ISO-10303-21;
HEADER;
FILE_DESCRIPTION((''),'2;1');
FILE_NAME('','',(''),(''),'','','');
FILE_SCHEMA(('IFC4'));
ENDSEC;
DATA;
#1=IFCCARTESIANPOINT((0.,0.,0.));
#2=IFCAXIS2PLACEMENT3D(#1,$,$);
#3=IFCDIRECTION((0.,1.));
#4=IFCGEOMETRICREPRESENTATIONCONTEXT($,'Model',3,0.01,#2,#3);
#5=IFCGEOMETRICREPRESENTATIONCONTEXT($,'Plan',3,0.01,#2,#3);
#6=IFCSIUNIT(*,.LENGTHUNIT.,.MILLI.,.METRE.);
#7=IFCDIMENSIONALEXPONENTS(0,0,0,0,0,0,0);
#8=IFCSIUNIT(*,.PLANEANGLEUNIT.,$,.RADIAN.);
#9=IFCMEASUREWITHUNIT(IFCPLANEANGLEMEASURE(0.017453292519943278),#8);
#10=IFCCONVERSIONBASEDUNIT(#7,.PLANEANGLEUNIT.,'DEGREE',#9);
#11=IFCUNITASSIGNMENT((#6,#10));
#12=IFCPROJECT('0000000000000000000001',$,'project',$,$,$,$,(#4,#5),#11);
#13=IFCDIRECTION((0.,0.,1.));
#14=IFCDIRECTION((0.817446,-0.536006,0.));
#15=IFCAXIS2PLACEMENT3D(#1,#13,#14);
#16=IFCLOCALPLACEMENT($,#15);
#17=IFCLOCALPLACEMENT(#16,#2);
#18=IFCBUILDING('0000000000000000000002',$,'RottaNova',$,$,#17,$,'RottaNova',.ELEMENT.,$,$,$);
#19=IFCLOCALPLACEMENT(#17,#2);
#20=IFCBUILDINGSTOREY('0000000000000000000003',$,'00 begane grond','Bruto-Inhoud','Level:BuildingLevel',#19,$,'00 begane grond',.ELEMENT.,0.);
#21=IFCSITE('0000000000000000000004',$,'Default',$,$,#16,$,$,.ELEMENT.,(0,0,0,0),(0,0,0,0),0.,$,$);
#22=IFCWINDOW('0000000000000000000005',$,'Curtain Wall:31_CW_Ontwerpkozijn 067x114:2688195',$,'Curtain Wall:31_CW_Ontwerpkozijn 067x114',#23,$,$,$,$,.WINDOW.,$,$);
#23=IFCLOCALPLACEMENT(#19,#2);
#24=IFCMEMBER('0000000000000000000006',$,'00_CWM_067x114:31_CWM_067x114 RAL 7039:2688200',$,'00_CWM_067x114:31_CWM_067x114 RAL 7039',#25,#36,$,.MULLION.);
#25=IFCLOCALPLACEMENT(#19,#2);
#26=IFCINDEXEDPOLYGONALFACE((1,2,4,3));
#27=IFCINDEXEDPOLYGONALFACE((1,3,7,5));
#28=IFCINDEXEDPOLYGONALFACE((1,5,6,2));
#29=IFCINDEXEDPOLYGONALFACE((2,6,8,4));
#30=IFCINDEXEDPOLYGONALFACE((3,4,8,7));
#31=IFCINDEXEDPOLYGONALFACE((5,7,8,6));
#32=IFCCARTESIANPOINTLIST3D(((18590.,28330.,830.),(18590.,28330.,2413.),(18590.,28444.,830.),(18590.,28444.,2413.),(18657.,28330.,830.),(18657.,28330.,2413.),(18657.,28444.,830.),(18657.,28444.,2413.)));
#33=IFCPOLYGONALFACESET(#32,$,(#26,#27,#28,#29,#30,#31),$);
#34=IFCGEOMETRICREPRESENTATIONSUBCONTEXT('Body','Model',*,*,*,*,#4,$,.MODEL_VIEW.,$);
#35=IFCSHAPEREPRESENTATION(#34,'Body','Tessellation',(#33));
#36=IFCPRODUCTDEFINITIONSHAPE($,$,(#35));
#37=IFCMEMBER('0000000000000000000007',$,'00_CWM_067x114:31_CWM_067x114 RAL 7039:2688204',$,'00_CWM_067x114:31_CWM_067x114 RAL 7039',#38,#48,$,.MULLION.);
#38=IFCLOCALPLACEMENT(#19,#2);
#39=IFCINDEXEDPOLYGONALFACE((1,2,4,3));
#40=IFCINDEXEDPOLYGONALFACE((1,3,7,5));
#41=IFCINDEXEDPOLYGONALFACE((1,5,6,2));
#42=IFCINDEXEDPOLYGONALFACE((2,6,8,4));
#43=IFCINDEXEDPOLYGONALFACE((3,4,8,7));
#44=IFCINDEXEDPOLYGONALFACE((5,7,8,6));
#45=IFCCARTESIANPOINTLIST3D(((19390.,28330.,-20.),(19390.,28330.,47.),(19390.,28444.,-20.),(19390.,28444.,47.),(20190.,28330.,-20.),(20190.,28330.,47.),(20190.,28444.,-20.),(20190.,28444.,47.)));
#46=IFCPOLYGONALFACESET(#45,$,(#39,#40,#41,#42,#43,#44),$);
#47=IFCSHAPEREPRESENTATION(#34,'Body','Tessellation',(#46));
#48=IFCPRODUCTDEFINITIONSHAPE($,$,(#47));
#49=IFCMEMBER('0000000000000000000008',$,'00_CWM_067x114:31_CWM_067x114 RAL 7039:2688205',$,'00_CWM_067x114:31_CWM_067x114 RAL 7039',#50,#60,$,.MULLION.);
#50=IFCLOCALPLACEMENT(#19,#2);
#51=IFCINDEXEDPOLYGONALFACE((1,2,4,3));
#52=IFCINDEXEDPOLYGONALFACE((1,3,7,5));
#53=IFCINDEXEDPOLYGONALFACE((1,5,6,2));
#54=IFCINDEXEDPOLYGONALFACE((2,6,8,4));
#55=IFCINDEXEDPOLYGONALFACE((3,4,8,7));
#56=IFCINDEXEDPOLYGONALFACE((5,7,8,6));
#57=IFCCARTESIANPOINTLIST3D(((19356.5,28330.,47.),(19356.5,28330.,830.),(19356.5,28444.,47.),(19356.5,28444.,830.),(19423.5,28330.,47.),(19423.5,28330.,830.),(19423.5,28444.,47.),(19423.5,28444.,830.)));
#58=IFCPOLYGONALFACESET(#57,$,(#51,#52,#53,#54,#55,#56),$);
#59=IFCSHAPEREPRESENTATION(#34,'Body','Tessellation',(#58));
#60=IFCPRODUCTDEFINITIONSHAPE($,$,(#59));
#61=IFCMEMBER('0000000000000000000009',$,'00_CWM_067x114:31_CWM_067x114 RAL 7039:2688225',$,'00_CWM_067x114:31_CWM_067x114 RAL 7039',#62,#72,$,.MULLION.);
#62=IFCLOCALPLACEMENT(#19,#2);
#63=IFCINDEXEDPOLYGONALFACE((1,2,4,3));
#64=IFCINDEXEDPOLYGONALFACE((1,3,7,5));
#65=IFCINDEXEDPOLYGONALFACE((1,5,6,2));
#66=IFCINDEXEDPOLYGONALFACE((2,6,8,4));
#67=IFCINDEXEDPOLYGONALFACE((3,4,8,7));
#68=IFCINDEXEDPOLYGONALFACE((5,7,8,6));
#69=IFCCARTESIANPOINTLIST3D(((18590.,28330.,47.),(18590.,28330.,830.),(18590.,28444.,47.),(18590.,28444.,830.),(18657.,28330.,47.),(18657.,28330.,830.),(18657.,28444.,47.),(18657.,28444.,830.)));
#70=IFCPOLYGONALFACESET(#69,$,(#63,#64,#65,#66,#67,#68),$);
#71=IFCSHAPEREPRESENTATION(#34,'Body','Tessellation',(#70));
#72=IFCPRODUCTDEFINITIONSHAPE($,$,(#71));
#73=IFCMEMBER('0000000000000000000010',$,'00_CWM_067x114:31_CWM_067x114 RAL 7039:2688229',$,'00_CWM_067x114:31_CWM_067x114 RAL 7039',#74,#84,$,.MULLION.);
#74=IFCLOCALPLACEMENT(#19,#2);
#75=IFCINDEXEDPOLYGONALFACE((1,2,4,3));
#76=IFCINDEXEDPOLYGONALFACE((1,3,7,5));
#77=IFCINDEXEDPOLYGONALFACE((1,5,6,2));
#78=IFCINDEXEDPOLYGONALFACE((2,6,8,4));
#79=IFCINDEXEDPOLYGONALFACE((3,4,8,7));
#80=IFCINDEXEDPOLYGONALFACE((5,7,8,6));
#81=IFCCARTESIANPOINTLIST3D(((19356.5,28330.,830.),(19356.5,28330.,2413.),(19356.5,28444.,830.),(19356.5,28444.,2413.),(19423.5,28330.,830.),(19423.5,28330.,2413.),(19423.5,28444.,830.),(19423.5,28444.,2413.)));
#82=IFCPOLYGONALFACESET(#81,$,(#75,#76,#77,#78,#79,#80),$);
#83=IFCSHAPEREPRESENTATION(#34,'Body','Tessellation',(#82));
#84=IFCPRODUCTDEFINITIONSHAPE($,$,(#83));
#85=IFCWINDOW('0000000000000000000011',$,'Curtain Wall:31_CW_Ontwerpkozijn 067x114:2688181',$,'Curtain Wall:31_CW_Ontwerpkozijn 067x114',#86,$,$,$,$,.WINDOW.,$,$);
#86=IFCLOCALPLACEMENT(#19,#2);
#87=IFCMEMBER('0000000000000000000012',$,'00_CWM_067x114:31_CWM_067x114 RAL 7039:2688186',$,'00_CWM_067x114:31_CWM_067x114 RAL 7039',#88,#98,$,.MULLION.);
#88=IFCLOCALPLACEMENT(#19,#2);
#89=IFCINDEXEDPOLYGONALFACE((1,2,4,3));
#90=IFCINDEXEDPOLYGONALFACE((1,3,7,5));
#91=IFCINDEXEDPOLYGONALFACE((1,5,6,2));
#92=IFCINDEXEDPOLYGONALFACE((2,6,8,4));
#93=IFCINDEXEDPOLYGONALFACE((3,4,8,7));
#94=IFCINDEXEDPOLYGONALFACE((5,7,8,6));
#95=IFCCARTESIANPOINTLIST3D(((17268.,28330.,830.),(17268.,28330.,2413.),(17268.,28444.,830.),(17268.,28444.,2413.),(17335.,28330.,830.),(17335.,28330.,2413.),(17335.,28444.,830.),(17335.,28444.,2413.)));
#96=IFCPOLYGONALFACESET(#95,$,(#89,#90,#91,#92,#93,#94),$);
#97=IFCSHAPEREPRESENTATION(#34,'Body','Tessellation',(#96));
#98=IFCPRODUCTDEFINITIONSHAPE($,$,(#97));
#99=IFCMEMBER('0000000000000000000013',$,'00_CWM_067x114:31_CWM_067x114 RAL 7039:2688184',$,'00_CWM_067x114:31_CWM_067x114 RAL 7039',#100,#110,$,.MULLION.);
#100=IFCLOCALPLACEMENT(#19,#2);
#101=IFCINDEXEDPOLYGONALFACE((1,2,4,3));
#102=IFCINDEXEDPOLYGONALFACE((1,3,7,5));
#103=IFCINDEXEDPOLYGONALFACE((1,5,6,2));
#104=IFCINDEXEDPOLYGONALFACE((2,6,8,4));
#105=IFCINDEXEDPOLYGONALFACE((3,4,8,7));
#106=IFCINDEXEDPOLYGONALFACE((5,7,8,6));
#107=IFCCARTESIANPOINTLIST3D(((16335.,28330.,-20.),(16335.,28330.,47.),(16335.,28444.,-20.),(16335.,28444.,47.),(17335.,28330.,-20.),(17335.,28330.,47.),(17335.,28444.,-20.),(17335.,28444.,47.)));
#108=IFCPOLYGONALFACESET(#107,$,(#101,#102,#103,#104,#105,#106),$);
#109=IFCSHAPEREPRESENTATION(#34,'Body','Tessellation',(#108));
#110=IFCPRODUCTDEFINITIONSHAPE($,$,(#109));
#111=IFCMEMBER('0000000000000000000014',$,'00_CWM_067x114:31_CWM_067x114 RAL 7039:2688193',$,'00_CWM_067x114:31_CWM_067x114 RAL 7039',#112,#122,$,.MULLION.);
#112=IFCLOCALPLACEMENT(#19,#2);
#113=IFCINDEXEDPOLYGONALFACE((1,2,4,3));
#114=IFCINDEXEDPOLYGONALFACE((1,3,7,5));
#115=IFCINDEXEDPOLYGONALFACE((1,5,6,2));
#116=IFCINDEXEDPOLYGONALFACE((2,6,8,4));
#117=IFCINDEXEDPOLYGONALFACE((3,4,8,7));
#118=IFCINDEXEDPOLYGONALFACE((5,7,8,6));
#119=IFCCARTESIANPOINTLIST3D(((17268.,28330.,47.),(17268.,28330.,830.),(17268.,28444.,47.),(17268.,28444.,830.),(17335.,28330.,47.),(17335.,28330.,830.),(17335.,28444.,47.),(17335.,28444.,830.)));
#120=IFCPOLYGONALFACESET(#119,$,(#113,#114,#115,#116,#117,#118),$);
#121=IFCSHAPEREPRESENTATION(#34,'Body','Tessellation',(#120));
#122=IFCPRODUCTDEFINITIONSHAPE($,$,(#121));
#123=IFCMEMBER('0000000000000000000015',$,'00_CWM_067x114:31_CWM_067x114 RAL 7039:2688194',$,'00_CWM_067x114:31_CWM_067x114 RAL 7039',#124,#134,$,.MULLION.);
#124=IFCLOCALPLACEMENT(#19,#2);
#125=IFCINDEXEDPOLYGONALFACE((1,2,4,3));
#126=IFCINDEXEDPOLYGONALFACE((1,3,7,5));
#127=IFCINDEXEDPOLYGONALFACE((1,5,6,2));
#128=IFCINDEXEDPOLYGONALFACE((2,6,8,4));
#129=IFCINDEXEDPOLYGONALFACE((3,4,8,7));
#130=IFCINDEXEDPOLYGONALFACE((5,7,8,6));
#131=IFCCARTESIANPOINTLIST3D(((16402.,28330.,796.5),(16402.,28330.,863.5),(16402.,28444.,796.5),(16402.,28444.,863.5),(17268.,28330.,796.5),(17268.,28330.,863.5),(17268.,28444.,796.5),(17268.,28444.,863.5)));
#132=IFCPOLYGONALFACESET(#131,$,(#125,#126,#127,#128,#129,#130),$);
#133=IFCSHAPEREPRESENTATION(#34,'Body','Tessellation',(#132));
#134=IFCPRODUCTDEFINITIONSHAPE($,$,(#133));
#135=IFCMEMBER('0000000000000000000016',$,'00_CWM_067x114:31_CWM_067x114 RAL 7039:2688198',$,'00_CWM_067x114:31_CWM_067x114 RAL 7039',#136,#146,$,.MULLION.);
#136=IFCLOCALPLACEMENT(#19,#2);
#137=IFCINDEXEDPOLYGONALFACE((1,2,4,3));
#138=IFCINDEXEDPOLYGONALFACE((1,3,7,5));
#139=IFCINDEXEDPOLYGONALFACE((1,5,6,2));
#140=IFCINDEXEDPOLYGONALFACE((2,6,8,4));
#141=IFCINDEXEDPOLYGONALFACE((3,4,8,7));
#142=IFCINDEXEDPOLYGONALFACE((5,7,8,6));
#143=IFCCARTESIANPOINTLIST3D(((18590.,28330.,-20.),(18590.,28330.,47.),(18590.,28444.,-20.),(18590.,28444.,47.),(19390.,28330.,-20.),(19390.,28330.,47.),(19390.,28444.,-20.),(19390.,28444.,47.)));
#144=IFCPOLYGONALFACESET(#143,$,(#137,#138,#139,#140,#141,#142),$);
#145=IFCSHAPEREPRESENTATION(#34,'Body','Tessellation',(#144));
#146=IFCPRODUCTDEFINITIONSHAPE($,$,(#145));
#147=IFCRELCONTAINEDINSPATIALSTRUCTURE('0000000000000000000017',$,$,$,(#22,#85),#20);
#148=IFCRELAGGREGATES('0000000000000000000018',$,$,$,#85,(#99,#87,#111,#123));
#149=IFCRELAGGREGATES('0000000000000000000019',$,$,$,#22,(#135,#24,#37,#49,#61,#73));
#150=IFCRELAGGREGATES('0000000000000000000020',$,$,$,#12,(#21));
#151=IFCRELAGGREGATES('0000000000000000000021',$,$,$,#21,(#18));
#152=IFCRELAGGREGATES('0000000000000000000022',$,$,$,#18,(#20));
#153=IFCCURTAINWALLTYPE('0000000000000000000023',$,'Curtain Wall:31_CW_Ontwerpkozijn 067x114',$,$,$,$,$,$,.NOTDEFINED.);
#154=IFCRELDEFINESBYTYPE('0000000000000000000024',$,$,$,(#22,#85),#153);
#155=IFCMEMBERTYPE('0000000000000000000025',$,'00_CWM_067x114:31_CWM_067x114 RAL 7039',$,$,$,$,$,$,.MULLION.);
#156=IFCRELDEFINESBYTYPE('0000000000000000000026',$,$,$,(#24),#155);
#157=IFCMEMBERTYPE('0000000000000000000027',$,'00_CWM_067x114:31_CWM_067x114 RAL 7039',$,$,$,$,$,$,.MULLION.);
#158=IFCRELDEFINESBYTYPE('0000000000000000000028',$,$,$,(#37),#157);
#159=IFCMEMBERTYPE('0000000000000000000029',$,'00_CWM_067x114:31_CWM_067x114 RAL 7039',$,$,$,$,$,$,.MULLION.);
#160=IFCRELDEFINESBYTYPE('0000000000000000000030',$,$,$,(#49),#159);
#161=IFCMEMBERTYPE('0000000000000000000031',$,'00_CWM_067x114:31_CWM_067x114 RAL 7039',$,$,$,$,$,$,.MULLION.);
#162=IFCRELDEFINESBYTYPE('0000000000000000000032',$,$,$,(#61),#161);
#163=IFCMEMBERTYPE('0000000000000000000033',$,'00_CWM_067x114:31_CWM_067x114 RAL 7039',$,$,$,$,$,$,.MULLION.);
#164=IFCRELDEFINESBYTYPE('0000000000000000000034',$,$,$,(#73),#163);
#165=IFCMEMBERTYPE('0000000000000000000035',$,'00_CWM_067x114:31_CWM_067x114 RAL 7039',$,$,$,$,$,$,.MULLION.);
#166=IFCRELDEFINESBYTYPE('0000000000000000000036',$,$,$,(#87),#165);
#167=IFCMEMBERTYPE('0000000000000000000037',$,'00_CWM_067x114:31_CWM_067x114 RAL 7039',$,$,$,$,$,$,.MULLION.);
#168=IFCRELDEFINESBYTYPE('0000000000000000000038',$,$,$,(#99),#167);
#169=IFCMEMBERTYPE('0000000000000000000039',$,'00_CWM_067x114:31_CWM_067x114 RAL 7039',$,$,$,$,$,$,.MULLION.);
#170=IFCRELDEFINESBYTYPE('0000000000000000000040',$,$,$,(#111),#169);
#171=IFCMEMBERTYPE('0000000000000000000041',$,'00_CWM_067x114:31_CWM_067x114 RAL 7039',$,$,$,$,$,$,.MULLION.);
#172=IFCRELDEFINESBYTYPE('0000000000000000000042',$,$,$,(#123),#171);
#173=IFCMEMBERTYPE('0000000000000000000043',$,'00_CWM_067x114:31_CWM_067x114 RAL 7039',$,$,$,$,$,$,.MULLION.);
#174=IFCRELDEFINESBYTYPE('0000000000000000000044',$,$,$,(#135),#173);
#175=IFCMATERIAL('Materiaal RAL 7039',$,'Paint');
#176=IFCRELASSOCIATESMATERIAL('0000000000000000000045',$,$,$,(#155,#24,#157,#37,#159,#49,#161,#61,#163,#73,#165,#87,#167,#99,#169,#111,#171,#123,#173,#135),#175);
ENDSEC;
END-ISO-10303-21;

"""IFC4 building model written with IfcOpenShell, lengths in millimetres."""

from ifc_helpers import new_model, entity, si_unit, converted_unit, direction, frame, origin, place, context, subcontext, project, spatial, indexed_curve, outline, extrude, source, transform, mapped, material, type_object, type_shapes, element, aggregate, save


model = new_model("IFC4")

# Units and contexts
model_context = context("Model", 3, precision=0.01, world=origin(), true_north=direction((0.0, 1.0)))
plan_context = context("Plan", 3, precision=0.01, world=origin(), true_north=direction((0.0, 1.0)))
body_context = subcontext(model_context, "Body", "Model", "MODEL_VIEW")
ifc_project = project(units=[si_unit("LENGTHUNIT", "METRE", prefix="MILLI"), converted_unit("PLANEANGLEUNIT", "DEGREE", entity("IfcPlaneAngleMeasure", 0.017453292519943278), si_unit("PLANEANGLEUNIT", "RADIAN"), dimensions=[0, 0, 0, 0, 0, 0, 0])], contexts=[model_context, plan_context])

# Site, building, storey
site_placement = place(None, frame((0.0, 0.0, 0.0), z_axis=(0.0, 0.0, 1.0), x_axis=(0.817446, -0.536006, 0.0)))
site = spatial("IfcSite", under=ifc_project, at=site_placement, Name="Default", CompositionType="ELEMENT", RefLatitude=(0, 0, 0, 0), RefLongitude=(0, 0, 0, 0), RefElevation=0.0)
building_placement = place(site_placement, origin())
building = spatial("IfcBuilding", under=site, at=building_placement, Name="RottaNova", LongName="RottaNova", CompositionType="ELEMENT")
storey_placement = place(building_placement, origin())
storey = spatial("IfcBuildingStorey", under=building, at=storey_placement, Name="00 begane grond", Description="Bruto-Inhoud", ObjectType="Level:BuildingLevel", LongName="00 begane grond", CompositionType="ELEMENT", Elevation=0.0)

# Windows, members
curtain_wall_type = type_object("IfcCurtainWallType", Name="Curtain Wall:31_CW_Ontwerpkozijn 067x114", PredefinedType="NOTDEFINED")
window_1_placement = place(storey_placement, origin())
window_1 = element("IfcWindow", 1, at=window_1_placement, inside=storey, type_object=curtain_wall_type, Name="Curtain Wall:31_CW_Ontwerpkozijn 067x114:2688195", ObjectType="Curtain Wall:31_CW_Ontwerpkozijn 067x114", PredefinedType="WINDOW")
ifc_material_1 = material(Name="Materiaal RAL 7039", Category="Paint")
member_type_1 = type_object("IfcMemberType", Name="00_CWM_067x114:31_CWM_067x114 RAL 7039", PredefinedType="MULLION", material=ifc_material_1)
shared_shape_1 = source(origin(), body_context, "Body", "SweptSolid", [
    extrude(outline(indexed_curve([(-33.5, -57.0), (33.5, -57.0), (33.5, 57.0), (-33.5, 57.0), (-33.5, -57.0)], self_intersect=False)), frame((-33.5, -57.0, -1583.0), z_axis=(0.0, 0.0, 1.0), x_axis=(-1.0, 0.0, 0.0)), (0.0, 0.0, 1.0), 1583.0),
])
type_shapes(member_type_1, [shared_shape_1])
member_1_placement = place(window_1_placement, frame((18590.0, 28330.0, 2413.0), z_axis=(0.0, 0.0, 1.0), x_axis=(-1.0, 0.0, 0.0)))
member_1 = element("IfcMember", 2, at=member_1_placement, type_object=member_type_1, material=ifc_material_1, Name="00_CWM_067x114:31_CWM_067x114 RAL 7039:2688200", ObjectType="00_CWM_067x114:31_CWM_067x114 RAL 7039", PredefinedType="MULLION", context=body_context, shape_type="MappedRepresentation", body=[
    mapped(shared_shape_1, transform((0.0, 0.0, 0.0), scale=1.0)),
])
member_type_2 = type_object("IfcMemberType", Name="00_CWM_067x114:31_CWM_067x114 RAL 7039", PredefinedType="MULLION", material=ifc_material_1)
shared_shape_2 = source(origin(), body_context, "Body", "SweptSolid", [
    extrude(outline(indexed_curve([(-33.5, -57.0), (33.5, -57.0), (33.5, 57.0), (-33.5, 57.0), (-33.5, -57.0)], self_intersect=False)), frame((-33.5, -57.0, -800.0), z_axis=(0.0, 0.0, 1.0), x_axis=(-1.0, 0.0, 0.0)), (0.0, 0.0, 1.0), 800.0),
])
type_shapes(member_type_2, [shared_shape_2])
member_2_placement = place(window_1_placement, frame((19390.0, 28330.0, -20.0), z_axis=(-1.0, 0.0, 0.0), x_axis=(0.0, 0.0, -1.0)))
member_2 = element("IfcMember", 3, at=member_2_placement, type_object=member_type_2, material=ifc_material_1, Name="00_CWM_067x114:31_CWM_067x114 RAL 7039:2688204", ObjectType="00_CWM_067x114:31_CWM_067x114 RAL 7039", PredefinedType="MULLION", context=body_context, shape_type="MappedRepresentation", body=[
    mapped(shared_shape_2, transform((0.0, 0.0, 0.0), scale=1.0)),
])
member_type_3 = type_object("IfcMemberType", Name="00_CWM_067x114:31_CWM_067x114 RAL 7039", PredefinedType="MULLION", material=ifc_material_1)
shared_shape_3 = source(origin(), body_context, "Body", "SweptSolid", [
    extrude(outline(indexed_curve([(-33.5, -57.0), (33.5, -57.0), (33.5, 57.0), (-33.5, 57.0), (-33.5, -57.0)], self_intersect=False)), frame((0.0, -57.0, -783.0), z_axis=(0.0, 0.0, 1.0), x_axis=(-1.0, 0.0, 0.0)), (0.0, 0.0, 1.0), 783.0),
])
type_shapes(member_type_3, [shared_shape_3])
member_3_placement = place(window_1_placement, frame((19390.0, 28330.0, 47.0), z_axis=(0.0, 0.0, -1.0), x_axis=(1.0, 0.0, 0.0)))
member_3 = element("IfcMember", 4, at=member_3_placement, type_object=member_type_3, material=ifc_material_1, Name="00_CWM_067x114:31_CWM_067x114 RAL 7039:2688205", ObjectType="00_CWM_067x114:31_CWM_067x114 RAL 7039", PredefinedType="MULLION", context=body_context, shape_type="MappedRepresentation", body=[
    mapped(shared_shape_3, transform((0.0, 0.0, 0.0), scale=1.0)),
])
member_type_4 = type_object("IfcMemberType", Name="00_CWM_067x114:31_CWM_067x114 RAL 7039", PredefinedType="MULLION", material=ifc_material_1)
shared_shape_4 = source(origin(), body_context, "Body", "SweptSolid", [
    extrude(outline(indexed_curve([(-33.5, -57.0), (33.5, -57.0), (33.5, 57.0), (-33.5, 57.0), (-33.5, -57.0)], self_intersect=False)), frame((-33.5, -57.0, -783.0), z_axis=(0.0, 0.0, 1.0), x_axis=(-1.0, 0.0, 0.0)), (0.0, 0.0, 1.0), 783.0),
])
type_shapes(member_type_4, [shared_shape_4])
member_4_placement = place(window_1_placement, frame((18590.0, 28330.0, 830.0), z_axis=(0.0, 0.0, 1.0), x_axis=(-1.0, 0.0, 0.0)))
member_4 = element("IfcMember", 5, at=member_4_placement, type_object=member_type_4, material=ifc_material_1, Name="00_CWM_067x114:31_CWM_067x114 RAL 7039:2688225", ObjectType="00_CWM_067x114:31_CWM_067x114 RAL 7039", PredefinedType="MULLION", context=body_context, shape_type="MappedRepresentation", body=[
    mapped(shared_shape_4, transform((0.0, 0.0, 0.0), scale=1.0)),
])
member_type_5 = type_object("IfcMemberType", Name="00_CWM_067x114:31_CWM_067x114 RAL 7039", PredefinedType="MULLION", material=ifc_material_1)
shared_shape_5 = source(origin(), body_context, "Body", "SweptSolid", [
    extrude(outline(indexed_curve([(-33.5, -57.0), (33.5, -57.0), (33.5, 57.0), (-33.5, 57.0), (-33.5, -57.0)], self_intersect=False)), frame((0.0, -57.0, -1583.0), z_axis=(0.0, 0.0, 1.0), x_axis=(-1.0, 0.0, 0.0)), (0.0, 0.0, 1.0), 1583.0),
])
type_shapes(member_type_5, [shared_shape_5])
member_5_placement = place(window_1_placement, frame((19390.0, 28330.0, 830.0), z_axis=(0.0, 0.0, -1.0), x_axis=(1.0, 0.0, 0.0)))
member_5 = element("IfcMember", 6, at=member_5_placement, type_object=member_type_5, material=ifc_material_1, Name="00_CWM_067x114:31_CWM_067x114 RAL 7039:2688229", ObjectType="00_CWM_067x114:31_CWM_067x114 RAL 7039", PredefinedType="MULLION", context=body_context, shape_type="MappedRepresentation", body=[
    mapped(shared_shape_5, transform((0.0, 0.0, 0.0), scale=1.0)),
])
window_2_placement = place(storey_placement, origin())
window_2 = element("IfcWindow", 7, at=window_2_placement, inside=storey, type_object=curtain_wall_type, Name="Curtain Wall:31_CW_Ontwerpkozijn 067x114:2688181", ObjectType="Curtain Wall:31_CW_Ontwerpkozijn 067x114", PredefinedType="WINDOW")
member_type_6 = type_object("IfcMemberType", Name="00_CWM_067x114:31_CWM_067x114 RAL 7039", PredefinedType="MULLION", material=ifc_material_1)
shared_shape_6 = source(origin(), body_context, "Body", "SweptSolid", [
    extrude(outline(indexed_curve([(-33.5, -57.0), (33.5, -57.0), (33.5, 57.0), (-33.5, 57.0), (-33.5, -57.0)], self_intersect=False)), frame((-33.5, 57.0, -1583.0), z_axis=(0.0, 0.0, 1.0), x_axis=(-1.0, 0.0, 0.0)), (0.0, 0.0, 1.0), 1583.0),
])
type_shapes(member_type_6, [shared_shape_6])
member_6_placement = place(window_2_placement, frame((17335.0, 28330.0, 2413.0)))
member_6 = element("IfcMember", 8, at=member_6_placement, type_object=member_type_6, material=ifc_material_1, Name="00_CWM_067x114:31_CWM_067x114 RAL 7039:2688186", ObjectType="00_CWM_067x114:31_CWM_067x114 RAL 7039", PredefinedType="MULLION", context=body_context, shape_type="MappedRepresentation", body=[
    mapped(shared_shape_6, transform((0.0, 0.0, 0.0), scale=1.0)),
])
member_type_7 = type_object("IfcMemberType", Name="00_CWM_067x114:31_CWM_067x114 RAL 7039", PredefinedType="MULLION", material=ifc_material_1)
shared_shape_7 = source(origin(), body_context, "Body", "SweptSolid", [
    extrude(outline(indexed_curve([(-33.5, -57.0), (33.5, -57.0), (33.5, 57.0), (-33.5, 57.0), (-33.5, -57.0)], self_intersect=False)), frame((-33.5, 57.0, -1000.0), z_axis=(0.0, 0.0, 1.0), x_axis=(-1.0, 0.0, 0.0)), (0.0, 0.0, 1.0), 1000.0),
])
type_shapes(member_type_7, [shared_shape_7])
member_7_placement = place(window_2_placement, frame((17335.0, 28330.0, -20.0), z_axis=(1.0, 0.0, 0.0), x_axis=(0.0, 0.0, -1.0)))
member_7 = element("IfcMember", 9, at=member_7_placement, type_object=member_type_7, material=ifc_material_1, Name="00_CWM_067x114:31_CWM_067x114 RAL 7039:2688184", ObjectType="00_CWM_067x114:31_CWM_067x114 RAL 7039", PredefinedType="MULLION", context=body_context, shape_type="MappedRepresentation", body=[
    mapped(shared_shape_7, transform((0.0, 0.0, 0.0), scale=1.0)),
])
member_type_8 = type_object("IfcMemberType", Name="00_CWM_067x114:31_CWM_067x114 RAL 7039", PredefinedType="MULLION", material=ifc_material_1)
shared_shape_8 = source(origin(), body_context, "Body", "SweptSolid", [
    extrude(outline(indexed_curve([(-33.5, -57.0), (33.5, -57.0), (33.5, 57.0), (-33.5, 57.0), (-33.5, -57.0)], self_intersect=False)), frame((-33.5, 57.0, -783.0), z_axis=(0.0, 0.0, 1.0), x_axis=(-1.0, 0.0, 0.0)), (0.0, 0.0, 1.0), 783.0),
])
type_shapes(member_type_8, [shared_shape_8])
member_8_placement = place(window_2_placement, frame((17335.0, 28330.0, 830.0)))
member_8 = element("IfcMember", 10, at=member_8_placement, type_object=member_type_8, material=ifc_material_1, Name="00_CWM_067x114:31_CWM_067x114 RAL 7039:2688193", ObjectType="00_CWM_067x114:31_CWM_067x114 RAL 7039", PredefinedType="MULLION", context=body_context, shape_type="MappedRepresentation", body=[
    mapped(shared_shape_8, transform((0.0, 0.0, 0.0), scale=1.0)),
])
member_type_9 = type_object("IfcMemberType", Name="00_CWM_067x114:31_CWM_067x114 RAL 7039", PredefinedType="MULLION", material=ifc_material_1)
shared_shape_9 = source(origin(), body_context, "Body", "SweptSolid", [
    extrude(outline(indexed_curve([(-33.5, -57.0), (33.5, -57.0), (33.5, 57.0), (-33.5, 57.0), (-33.5, -57.0)], self_intersect=False)), frame((0.0, 57.0, -866.0), z_axis=(0.0, 0.0, 1.0), x_axis=(-1.0, 0.0, 0.0)), (0.0, 0.0, 1.0), 866.0),
])
type_shapes(member_type_9, [shared_shape_9])
member_9_placement = place(window_2_placement, frame((16402.0, 28330.0, 830.0), z_axis=(-1.0, 0.0, 0.0), x_axis=(0.0, 0.0, 1.0)))
member_9 = element("IfcMember", 11, at=member_9_placement, type_object=member_type_9, material=ifc_material_1, Name="00_CWM_067x114:31_CWM_067x114 RAL 7039:2688194", ObjectType="00_CWM_067x114:31_CWM_067x114 RAL 7039", PredefinedType="MULLION", context=body_context, shape_type="MappedRepresentation", body=[
    mapped(shared_shape_9, transform((0.0, 0.0, 0.0), scale=1.0)),
])

# Member
member_type_10 = type_object("IfcMemberType", Name="00_CWM_067x114:31_CWM_067x114 RAL 7039", PredefinedType="MULLION", material=ifc_material_1)
shared_shape_10 = source(origin(), body_context, "Body", "SweptSolid", [
    extrude(outline(indexed_curve([(-33.5, -57.0), (33.5, -57.0), (33.5, 57.0), (-33.5, 57.0), (-33.5, -57.0)], self_intersect=False)), frame((-33.5, -57.0, -800.0), z_axis=(0.0, 0.0, 1.0), x_axis=(-1.0, 0.0, 0.0)), (0.0, 0.0, 1.0), 800.0),
])
type_shapes(member_type_10, [shared_shape_10])
member_10_placement = place(window_1_placement, frame((18590.0, 28330.0, -20.0), z_axis=(-1.0, 0.0, 0.0), x_axis=(0.0, 0.0, -1.0)))
member_10 = element("IfcMember", 12, at=member_10_placement, type_object=member_type_10, material=ifc_material_1, Name="00_CWM_067x114:31_CWM_067x114 RAL 7039:2688198", ObjectType="00_CWM_067x114:31_CWM_067x114 RAL 7039", PredefinedType="MULLION", context=body_context, shape_type="MappedRepresentation", body=[
    mapped(shared_shape_10, transform((0.0, 0.0, 0.0), scale=1.0)),
])

aggregate(window_2, [member_7, member_6, member_8, member_9])
aggregate(window_1, [member_10, member_1, member_2, member_3, member_4, member_5])

save(model, "model.ifc")
